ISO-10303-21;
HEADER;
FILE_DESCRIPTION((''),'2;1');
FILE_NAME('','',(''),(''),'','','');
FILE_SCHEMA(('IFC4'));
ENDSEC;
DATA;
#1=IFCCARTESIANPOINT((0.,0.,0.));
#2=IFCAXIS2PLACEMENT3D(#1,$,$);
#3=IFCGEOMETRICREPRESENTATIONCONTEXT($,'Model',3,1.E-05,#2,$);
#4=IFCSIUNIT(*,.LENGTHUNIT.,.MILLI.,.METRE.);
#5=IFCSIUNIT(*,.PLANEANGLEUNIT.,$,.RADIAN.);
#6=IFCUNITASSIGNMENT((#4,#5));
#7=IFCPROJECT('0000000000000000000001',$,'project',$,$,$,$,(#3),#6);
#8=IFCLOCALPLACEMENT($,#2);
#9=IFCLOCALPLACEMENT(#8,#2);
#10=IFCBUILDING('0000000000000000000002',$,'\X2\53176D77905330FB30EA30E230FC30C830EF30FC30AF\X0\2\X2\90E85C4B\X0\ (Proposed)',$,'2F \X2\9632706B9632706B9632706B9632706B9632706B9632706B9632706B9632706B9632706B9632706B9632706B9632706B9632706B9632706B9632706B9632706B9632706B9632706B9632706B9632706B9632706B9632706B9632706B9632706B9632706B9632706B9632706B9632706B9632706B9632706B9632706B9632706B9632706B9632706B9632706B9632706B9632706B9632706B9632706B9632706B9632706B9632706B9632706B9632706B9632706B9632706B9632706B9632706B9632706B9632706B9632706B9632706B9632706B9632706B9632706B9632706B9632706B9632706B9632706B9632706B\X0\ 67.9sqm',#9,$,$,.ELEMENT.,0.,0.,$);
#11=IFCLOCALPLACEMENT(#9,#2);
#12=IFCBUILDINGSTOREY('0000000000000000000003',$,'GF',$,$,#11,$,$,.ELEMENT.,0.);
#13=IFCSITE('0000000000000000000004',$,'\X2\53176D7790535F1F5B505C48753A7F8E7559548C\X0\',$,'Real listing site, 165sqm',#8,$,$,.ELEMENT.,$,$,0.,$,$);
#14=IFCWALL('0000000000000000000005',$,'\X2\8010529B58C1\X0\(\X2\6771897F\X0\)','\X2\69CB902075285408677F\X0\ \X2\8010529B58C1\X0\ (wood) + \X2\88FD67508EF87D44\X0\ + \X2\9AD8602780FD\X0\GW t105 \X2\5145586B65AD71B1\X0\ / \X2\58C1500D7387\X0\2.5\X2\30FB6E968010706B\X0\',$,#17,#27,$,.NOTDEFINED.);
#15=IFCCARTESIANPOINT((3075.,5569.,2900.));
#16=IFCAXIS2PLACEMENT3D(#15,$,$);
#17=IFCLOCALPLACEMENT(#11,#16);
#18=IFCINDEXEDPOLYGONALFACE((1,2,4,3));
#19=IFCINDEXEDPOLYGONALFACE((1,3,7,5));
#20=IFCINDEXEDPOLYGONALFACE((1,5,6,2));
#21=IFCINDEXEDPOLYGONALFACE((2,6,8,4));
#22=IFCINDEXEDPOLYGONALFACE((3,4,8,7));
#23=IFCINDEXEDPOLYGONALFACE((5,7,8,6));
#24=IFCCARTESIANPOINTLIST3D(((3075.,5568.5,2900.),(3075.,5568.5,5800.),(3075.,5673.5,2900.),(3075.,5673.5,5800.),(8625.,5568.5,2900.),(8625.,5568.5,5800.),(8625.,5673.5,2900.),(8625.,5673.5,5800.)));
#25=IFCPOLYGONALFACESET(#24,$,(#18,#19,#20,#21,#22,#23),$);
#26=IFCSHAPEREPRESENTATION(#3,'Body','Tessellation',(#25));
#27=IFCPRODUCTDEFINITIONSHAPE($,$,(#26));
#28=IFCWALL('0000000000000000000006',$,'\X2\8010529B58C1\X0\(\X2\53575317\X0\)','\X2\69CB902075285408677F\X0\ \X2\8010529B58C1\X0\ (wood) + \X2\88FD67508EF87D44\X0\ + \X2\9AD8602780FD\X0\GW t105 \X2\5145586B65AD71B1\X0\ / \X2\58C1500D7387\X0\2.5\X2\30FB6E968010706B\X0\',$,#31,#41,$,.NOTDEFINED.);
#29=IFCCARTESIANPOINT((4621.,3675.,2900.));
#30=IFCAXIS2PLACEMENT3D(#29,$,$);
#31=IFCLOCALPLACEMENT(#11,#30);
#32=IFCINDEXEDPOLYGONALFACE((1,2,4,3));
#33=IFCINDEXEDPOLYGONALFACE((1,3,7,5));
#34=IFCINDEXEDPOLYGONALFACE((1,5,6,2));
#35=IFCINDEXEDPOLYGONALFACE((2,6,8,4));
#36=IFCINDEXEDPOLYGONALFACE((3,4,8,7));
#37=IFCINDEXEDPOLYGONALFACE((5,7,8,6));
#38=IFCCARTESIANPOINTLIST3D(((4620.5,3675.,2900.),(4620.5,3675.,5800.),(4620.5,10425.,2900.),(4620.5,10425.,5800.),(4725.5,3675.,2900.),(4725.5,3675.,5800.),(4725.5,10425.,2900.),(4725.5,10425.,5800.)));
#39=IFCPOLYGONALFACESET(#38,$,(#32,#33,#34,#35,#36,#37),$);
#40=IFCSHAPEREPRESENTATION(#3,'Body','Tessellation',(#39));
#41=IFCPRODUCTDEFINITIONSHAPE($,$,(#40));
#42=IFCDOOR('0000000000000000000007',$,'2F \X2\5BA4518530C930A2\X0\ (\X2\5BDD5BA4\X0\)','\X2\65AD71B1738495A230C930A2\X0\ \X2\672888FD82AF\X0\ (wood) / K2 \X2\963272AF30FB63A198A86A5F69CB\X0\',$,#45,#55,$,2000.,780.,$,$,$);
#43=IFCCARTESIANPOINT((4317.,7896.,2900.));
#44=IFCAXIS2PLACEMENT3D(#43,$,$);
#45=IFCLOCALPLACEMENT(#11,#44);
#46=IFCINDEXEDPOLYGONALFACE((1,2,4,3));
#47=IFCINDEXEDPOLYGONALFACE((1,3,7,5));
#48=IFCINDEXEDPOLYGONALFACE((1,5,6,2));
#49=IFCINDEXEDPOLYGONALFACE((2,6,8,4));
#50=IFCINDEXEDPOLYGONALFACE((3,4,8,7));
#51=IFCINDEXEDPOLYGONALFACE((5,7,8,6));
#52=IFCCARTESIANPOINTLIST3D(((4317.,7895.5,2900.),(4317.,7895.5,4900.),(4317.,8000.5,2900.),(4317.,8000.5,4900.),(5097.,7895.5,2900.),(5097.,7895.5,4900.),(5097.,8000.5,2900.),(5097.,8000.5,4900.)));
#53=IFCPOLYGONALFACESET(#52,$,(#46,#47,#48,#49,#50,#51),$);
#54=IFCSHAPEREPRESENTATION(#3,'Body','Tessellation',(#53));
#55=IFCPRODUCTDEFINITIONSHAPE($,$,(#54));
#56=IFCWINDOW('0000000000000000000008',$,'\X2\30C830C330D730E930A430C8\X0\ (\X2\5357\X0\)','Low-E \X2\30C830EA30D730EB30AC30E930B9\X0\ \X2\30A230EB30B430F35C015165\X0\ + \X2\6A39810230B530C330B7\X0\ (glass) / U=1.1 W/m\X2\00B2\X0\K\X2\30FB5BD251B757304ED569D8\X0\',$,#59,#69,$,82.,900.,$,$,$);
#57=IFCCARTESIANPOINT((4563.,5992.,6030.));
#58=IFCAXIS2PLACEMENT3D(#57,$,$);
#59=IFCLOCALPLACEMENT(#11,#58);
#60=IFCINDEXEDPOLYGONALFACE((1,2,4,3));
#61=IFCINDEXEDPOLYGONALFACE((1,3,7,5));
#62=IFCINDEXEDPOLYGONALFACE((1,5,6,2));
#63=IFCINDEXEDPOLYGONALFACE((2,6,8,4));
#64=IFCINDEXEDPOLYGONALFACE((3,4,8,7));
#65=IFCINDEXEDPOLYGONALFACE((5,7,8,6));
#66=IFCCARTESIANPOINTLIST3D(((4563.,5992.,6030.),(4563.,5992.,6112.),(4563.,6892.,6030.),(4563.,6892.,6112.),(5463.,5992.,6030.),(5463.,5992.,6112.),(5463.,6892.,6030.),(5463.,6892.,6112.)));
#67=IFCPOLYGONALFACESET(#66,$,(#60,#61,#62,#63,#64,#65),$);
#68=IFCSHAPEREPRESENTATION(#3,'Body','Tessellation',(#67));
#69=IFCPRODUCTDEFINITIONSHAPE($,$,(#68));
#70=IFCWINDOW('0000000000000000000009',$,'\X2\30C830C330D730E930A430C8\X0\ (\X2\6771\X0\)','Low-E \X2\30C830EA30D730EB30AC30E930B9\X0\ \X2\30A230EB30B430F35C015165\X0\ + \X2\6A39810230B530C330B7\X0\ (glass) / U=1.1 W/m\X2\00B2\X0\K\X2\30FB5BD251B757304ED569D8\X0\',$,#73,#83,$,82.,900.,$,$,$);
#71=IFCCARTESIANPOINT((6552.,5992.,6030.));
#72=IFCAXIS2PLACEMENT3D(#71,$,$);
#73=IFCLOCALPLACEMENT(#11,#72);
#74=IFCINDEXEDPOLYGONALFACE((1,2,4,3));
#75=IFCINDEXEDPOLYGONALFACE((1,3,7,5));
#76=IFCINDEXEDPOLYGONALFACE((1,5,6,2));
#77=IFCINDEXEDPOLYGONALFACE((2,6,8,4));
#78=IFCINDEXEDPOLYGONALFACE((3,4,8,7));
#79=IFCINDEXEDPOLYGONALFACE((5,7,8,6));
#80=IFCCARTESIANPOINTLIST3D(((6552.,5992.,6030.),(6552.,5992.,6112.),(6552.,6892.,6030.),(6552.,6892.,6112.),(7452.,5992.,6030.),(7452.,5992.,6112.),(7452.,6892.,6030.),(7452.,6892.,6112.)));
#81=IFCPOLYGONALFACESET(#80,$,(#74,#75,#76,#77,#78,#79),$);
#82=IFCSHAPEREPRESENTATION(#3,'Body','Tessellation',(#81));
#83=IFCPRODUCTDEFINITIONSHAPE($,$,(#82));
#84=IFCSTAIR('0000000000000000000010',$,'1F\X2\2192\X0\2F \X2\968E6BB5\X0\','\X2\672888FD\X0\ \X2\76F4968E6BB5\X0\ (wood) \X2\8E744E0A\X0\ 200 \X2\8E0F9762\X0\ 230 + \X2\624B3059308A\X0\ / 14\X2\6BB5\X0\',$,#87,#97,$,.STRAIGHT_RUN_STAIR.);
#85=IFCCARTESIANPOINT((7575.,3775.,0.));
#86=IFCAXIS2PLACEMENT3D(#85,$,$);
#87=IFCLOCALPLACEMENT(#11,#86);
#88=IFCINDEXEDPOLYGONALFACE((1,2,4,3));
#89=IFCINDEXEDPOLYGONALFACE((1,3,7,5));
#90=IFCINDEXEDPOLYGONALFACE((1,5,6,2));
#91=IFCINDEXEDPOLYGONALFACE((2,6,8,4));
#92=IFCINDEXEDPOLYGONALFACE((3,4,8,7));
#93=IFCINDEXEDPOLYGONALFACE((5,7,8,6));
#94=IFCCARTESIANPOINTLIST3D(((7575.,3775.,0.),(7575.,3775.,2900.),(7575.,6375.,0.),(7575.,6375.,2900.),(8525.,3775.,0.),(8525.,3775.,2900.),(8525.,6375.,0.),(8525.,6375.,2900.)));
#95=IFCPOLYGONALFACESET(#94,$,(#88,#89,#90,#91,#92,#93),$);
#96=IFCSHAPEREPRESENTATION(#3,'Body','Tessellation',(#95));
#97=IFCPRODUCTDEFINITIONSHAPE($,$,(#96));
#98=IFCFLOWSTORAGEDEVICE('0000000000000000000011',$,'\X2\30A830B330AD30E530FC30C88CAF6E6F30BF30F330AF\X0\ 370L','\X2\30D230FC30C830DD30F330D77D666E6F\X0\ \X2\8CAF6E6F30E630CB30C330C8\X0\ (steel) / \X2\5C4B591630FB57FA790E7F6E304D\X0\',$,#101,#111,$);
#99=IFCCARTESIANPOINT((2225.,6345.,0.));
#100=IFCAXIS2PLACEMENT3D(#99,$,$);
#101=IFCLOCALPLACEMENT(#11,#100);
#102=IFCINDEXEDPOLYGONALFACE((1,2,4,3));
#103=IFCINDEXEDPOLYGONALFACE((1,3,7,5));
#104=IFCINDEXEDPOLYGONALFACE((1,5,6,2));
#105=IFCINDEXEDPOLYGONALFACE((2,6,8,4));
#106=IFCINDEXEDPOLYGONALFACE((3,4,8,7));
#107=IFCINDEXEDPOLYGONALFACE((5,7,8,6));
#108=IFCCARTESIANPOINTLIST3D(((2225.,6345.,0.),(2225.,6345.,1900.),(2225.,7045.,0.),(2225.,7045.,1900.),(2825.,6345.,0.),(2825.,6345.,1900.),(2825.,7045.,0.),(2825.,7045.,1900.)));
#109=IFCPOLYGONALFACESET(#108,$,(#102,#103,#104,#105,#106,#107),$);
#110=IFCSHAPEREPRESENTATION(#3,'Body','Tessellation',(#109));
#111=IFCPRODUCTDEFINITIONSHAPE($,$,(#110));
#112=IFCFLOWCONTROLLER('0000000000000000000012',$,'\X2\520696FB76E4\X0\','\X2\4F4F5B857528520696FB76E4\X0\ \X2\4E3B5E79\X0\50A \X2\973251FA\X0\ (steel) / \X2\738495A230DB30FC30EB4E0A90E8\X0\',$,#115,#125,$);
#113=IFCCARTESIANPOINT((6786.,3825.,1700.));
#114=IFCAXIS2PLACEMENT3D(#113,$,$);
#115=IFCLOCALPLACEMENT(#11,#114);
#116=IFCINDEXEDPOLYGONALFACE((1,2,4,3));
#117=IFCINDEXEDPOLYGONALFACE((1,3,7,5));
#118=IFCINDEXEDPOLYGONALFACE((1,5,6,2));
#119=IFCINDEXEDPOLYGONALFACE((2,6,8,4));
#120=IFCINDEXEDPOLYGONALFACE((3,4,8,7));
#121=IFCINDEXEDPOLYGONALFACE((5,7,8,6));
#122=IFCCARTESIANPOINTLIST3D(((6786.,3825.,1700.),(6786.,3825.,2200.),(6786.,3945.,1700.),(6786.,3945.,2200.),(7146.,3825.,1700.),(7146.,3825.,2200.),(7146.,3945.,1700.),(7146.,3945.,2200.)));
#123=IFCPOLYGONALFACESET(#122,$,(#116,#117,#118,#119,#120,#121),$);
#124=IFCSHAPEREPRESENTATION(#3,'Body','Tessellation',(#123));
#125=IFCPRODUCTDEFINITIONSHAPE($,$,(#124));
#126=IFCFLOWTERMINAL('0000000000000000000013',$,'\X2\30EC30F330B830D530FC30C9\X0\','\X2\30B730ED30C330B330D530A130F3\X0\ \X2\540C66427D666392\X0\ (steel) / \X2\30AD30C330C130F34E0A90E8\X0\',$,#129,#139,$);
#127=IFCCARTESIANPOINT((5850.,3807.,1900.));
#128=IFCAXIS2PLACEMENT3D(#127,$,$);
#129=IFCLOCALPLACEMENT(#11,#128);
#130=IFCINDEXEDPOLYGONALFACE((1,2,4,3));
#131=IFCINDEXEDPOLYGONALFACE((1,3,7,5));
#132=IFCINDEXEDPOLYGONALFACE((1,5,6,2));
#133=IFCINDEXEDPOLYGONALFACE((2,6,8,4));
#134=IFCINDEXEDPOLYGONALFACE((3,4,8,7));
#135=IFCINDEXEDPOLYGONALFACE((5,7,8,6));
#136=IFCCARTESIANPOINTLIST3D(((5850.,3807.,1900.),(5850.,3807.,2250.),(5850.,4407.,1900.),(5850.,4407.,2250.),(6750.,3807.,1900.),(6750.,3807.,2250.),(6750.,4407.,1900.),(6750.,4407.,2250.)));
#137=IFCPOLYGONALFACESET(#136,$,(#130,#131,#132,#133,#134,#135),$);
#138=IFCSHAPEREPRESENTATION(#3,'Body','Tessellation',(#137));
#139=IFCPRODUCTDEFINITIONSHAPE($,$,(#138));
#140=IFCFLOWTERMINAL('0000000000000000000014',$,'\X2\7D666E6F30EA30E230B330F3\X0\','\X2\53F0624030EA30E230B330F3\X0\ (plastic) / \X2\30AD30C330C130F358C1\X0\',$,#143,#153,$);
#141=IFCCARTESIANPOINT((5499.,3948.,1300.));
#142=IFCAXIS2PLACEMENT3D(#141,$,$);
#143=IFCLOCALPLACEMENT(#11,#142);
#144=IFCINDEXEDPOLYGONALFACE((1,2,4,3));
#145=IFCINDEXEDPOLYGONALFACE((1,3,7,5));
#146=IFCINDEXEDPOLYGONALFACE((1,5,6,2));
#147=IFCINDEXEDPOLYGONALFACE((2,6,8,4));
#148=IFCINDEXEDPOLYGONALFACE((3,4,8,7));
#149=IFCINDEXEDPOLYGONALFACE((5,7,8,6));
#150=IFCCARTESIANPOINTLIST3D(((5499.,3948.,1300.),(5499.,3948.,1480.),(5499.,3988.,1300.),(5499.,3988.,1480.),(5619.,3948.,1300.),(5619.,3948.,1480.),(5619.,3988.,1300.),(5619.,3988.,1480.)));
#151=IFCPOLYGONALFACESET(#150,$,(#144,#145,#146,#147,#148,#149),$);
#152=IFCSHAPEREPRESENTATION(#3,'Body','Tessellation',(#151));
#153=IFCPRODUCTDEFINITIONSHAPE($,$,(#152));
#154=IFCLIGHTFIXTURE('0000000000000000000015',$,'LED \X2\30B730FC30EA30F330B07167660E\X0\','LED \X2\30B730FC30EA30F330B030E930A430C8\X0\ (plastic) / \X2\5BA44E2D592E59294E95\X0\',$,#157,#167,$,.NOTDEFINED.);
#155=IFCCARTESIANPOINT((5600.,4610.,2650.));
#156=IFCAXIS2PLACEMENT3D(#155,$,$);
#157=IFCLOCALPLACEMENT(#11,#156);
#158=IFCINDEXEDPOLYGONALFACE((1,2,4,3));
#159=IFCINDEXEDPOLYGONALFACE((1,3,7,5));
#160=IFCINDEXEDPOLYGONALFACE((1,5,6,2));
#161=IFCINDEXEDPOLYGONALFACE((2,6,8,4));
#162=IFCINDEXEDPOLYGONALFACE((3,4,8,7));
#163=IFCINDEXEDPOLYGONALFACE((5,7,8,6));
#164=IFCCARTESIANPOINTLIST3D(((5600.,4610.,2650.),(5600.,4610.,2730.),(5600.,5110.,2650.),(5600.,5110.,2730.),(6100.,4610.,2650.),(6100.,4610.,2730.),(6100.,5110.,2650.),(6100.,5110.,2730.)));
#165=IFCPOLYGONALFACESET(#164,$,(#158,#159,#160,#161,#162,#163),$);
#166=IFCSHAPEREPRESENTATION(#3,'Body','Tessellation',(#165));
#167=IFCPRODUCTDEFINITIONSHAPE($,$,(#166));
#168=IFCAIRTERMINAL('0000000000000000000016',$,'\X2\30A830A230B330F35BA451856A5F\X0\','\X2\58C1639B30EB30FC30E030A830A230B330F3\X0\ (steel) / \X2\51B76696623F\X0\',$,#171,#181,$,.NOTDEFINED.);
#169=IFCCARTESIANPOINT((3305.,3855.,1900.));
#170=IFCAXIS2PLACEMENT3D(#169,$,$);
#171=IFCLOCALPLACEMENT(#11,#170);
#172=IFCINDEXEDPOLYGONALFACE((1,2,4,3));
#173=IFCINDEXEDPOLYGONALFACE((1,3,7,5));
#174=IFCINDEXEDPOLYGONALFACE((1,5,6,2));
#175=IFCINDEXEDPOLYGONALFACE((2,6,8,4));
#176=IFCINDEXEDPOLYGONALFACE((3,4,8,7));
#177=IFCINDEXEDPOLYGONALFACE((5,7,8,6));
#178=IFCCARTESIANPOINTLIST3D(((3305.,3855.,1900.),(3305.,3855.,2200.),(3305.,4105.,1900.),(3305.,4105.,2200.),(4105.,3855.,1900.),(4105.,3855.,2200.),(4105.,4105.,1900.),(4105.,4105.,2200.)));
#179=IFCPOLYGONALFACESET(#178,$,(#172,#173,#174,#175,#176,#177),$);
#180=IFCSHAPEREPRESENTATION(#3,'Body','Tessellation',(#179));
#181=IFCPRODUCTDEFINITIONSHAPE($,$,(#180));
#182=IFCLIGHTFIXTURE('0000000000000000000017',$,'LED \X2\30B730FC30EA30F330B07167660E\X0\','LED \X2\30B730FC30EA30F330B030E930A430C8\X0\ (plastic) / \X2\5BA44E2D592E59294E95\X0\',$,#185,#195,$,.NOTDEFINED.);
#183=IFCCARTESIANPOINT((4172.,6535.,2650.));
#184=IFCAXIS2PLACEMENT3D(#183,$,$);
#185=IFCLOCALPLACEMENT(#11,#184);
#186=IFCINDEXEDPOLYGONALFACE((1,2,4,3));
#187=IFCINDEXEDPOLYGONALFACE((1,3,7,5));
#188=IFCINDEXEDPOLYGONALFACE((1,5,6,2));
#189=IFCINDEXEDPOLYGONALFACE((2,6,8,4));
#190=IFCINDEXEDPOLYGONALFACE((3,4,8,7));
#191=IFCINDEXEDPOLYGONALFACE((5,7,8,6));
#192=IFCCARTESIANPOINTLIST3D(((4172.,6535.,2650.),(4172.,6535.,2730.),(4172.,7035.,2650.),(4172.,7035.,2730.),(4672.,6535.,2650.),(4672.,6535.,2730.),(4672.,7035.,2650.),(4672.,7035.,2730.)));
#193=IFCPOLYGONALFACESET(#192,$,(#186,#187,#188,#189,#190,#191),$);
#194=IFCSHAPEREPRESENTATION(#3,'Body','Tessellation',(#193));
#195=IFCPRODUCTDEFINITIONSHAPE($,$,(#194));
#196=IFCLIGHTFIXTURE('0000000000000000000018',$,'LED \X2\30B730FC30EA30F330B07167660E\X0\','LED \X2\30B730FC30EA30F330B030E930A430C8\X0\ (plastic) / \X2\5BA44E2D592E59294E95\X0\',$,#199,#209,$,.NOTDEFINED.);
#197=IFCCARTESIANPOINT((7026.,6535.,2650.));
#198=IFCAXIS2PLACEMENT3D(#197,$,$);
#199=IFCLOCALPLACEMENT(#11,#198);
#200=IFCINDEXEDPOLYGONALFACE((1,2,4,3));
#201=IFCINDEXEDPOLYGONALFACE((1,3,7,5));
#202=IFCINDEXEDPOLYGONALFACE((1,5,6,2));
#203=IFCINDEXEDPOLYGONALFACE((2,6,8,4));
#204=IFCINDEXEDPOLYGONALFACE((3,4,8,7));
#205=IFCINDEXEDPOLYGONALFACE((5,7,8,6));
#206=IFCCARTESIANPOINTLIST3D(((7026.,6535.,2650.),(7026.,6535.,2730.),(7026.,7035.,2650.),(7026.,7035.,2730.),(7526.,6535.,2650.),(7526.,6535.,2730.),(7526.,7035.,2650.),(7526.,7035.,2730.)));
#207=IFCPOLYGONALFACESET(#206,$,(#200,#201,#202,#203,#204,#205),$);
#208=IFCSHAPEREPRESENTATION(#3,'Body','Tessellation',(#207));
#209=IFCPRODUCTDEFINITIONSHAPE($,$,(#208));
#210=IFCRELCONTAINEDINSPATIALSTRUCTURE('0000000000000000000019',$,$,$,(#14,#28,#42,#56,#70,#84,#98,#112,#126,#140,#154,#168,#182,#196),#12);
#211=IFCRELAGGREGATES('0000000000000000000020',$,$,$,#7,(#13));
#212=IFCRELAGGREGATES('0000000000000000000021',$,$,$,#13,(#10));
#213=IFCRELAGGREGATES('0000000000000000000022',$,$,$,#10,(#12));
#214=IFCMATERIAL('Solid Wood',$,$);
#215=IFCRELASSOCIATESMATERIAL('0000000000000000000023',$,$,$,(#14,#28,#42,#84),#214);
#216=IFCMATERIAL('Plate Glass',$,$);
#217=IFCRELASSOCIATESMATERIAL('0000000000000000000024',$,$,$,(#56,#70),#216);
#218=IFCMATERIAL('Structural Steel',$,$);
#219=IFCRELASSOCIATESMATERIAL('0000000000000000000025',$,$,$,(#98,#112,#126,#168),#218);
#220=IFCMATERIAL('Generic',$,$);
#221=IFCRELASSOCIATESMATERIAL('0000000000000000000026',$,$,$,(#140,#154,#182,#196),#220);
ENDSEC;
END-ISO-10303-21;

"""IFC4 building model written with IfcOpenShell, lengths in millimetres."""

from ifc_helpers import new_model, si_unit, frame, frame_2d, origin, place, context, project, spatial, rectangle, extrude, material, element, fill, save


model = new_model("IFC4")

# Units and contexts
model_context = context("Model", 3, precision=1e-05, world=origin())
ifc_project = project(units=[si_unit("LENGTHUNIT", "METRE", prefix="MILLI"), si_unit("PLANEANGLEUNIT", "RADIAN")], contexts=[model_context])

# Site, building, storey
site_placement = place(None, origin())
site = spatial("IfcSite", under=ifc_project, at=site_placement, Name="北海道弟子屈町美留和", ObjectType="Real listing site, 165sqm", CompositionType="ELEMENT", RefElevation=0.0)
building_placement = place(site_placement, origin())
building = spatial("IfcBuilding", under=site, at=building_placement, Name="北海道・リモートワーク2部屋 (Proposed)", ObjectType="2F 防火防火防火防火防火防火防火防火防火防火防火防火防火防火防火防火防火防火防火防火防火防火防火防火防火防火防火防火防火防火防火防火防火防火防火防火防火防火防火防火防火防火防火防火防火防火防火防火防火防火防火防火防火防火防火防火防火防火防火防火 67.9sqm", CompositionType="ELEMENT", ElevationOfRefHeight=0.0, ElevationOfTerrain=0.0)
storey_placement = place(building_placement, origin())
storey = spatial("IfcBuildingStorey", under=building, at=storey_placement, Name="GF", CompositionType="ELEMENT", Elevation=0.0)

# Shared definitions
ifc_material_1 = material(Name="Solid Wood")

# Wall
wall_1_placement = place(storey_placement, frame((3075.0, 5569.0, 2900.0)))
element("IfcWall", 1, at=wall_1_placement, inside=storey, material=ifc_material_1, Name="耐力壁(東西)", Description="構造用合板 耐力壁 (wood) + 製材軸組 + 高性能GW t105 充填断熱 / 壁倍率2.5・準耐火", PredefinedType="NOTDEFINED", context=model_context, shape_type="SweptSolid", body=[
    extrude(rectangle(XDim=5550.0, YDim=105.0, at=frame_2d((2775.0, 52.0))), frame((3075.0, 5569.0, 2900.0)), (0.0, 0.0, 1.0), 2900.0),
])

# Wall, opening, door
wall_2_placement = place(storey_placement, frame((4621.0, 3675.0, 2900.0)))
wall_2 = element("IfcWall", 2, at=wall_2_placement, inside=storey, material=ifc_material_1, Name="耐力壁(南北)", Description="構造用合板 耐力壁 (wood) + 製材軸組 + 高性能GW t105 充填断熱 / 壁倍率2.5・準耐火", PredefinedType="NOTDEFINED", context=model_context, shape_type="SweptSolid", body=[
    extrude(rectangle(XDim=105.0, YDim=6750.0, at=frame_2d((52.0, 3375.0))), frame((4621.0, 3675.0, 2900.0)), (0.0, 0.0, 1.0), 2900.0),
])
opening_placement = place(storey_placement, frame((4317.0, 7896.0, 2900.0)))
opening = element("IfcOpeningElement", 3, at=opening_placement, cuts=wall_2, PredefinedType="NOTDEFINED", context=model_context, shape_type="SweptSolid", body=[
    extrude(rectangle(XDim=780.0, YDim=105.0, at=frame_2d((390.0, 52.0))), frame((4317.0, 7896.0, 2900.0)), (0.0, 0.0, 1.0), 2000.0),
])
door_placement = place(storey_placement, frame((4317.0, 7896.0, 2900.0)))
door = element("IfcDoor", 4, at=door_placement, inside=storey, material=ifc_material_1, Name="2F 室内ドア (寝室)", Description="断熱玄関ドア 木製芯 (wood) / K2 防犯・採風機構", OverallHeight=2000.0, OverallWidth=780.0, context=model_context, shape_type="SweptSolid", body=[
    extrude(rectangle(XDim=780.0, YDim=105.0, at=frame_2d((390.0, 52.0))), frame((4317.0, 7896.0, 2900.0)), (0.0, 0.0, 1.0), 2000.0),
])
fill(opening, door)

# Windows
ifc_material_2 = material(Name="Plate Glass")
window_1_placement = place(storey_placement, frame((4563.0, 5992.0, 6030.0)))
element("IfcWindow", 5, at=window_1_placement, inside=storey, material=ifc_material_2, Name="トップライト (南)", Description="Low-E トリプルガラス アルゴン封入 + 樹脂サッシ (glass) / U=1.1 W/m²K・寒冷地仕様", OverallHeight=82.0, OverallWidth=900.0, context=model_context, shape_type="SweptSolid", body=[
    extrude(rectangle(XDim=900.0, YDim=900.0, at=frame_2d((450.0, 450.0))), frame((4563.0, 5992.0, 6030.0)), (0.0, 0.0, 1.0), 82.0),
])
window_2_placement = place(storey_placement, frame((6552.0, 5992.0, 6030.0)))
element("IfcWindow", 6, at=window_2_placement, inside=storey, material=ifc_material_2, Name="トップライト (東)", Description="Low-E トリプルガラス アルゴン封入 + 樹脂サッシ (glass) / U=1.1 W/m²K・寒冷地仕様", OverallHeight=82.0, OverallWidth=900.0, context=model_context, shape_type="SweptSolid", body=[
    extrude(rectangle(XDim=900.0, YDim=900.0, at=frame_2d((450.0, 450.0))), frame((6552.0, 5992.0, 6030.0)), (0.0, 0.0, 1.0), 82.0),
])

# Stair
stair_placement = place(storey_placement, frame((7575.0, 3775.0, 0.0)))
element("IfcStair", 7, at=stair_placement, inside=storey, material=ifc_material_1, Name="1F→2F 階段", Description="木製 直階段 (wood) 蹴上 200 踏面 230 + 手すり / 14段", PredefinedType="STRAIGHT_RUN_STAIR", context=model_context, shape_type="SweptSolid", body=[
    extrude(rectangle(XDim=950.0, YDim=2600.0, at=frame_2d((475.0, 1300.0))), frame((7575.0, 3775.0, 0.0)), (0.0, 0.0, 1.0), 2900.0),
])

# Flow storage device
ifc_material_3 = material(Name="Structural Steel")
flow_storage_device_placement = place(storey_placement, frame((2225.0, 6345.0, 0.0)))
element("IfcFlowStorageDevice", 8, at=flow_storage_device_placement, inside=storey, material=ifc_material_3, Name="エコキュート貯湯タンク 370L", Description="ヒートポンプ給湯 貯湯ユニット (steel) / 屋外・基礎置き", context=model_context, shape_type="SweptSolid", body=[
    extrude(rectangle(XDim=600.0, YDim=700.0, at=frame_2d((300.0, 350.0))), frame((2225.0, 6345.0, 0.0)), (0.0, 0.0, 1.0), 1900.0),
])

# Flow controller
flow_controller_placement = place(storey_placement, frame((6786.0, 3825.0, 1700.0)))
element("IfcFlowController", 9, at=flow_controller_placement, inside=storey, material=ifc_material_3, Name="分電盤", Description="住宅用分電盤 主幹50A 露出 (steel) / 玄関ホール上部", context=model_context, shape_type="SweptSolid", body=[
    extrude(rectangle(XDim=360.0, YDim=120.0, at=frame_2d((180.0, 60.0))), frame((6786.0, 3825.0, 1700.0)), (0.0, 0.0, 1.0), 500.0),
])

# Flow terminals
flow_terminal_1_placement = place(storey_placement, frame((5850.0, 3807.0, 1900.0)))
element("IfcFlowTerminal", 10, at=flow_terminal_1_placement, inside=storey, material=ifc_material_3, Name="レンジフード", Description="シロッコファン 同時給排 (steel) / キッチン上部", context=model_context, shape_type="SweptSolid", body=[
    extrude(rectangle(XDim=900.0, YDim=600.0, at=frame_2d((450.0, 300.0))), frame((5850.0, 3807.0, 1900.0)), (0.0, 0.0, 1.0), 350.0),
])
ifc_material_4 = material(Name="Generic")
flow_terminal_2_placement = place(storey_placement, frame((5499.0, 3948.0, 1300.0)))
element("IfcFlowTerminal", 11, at=flow_terminal_2_placement, inside=storey, material=ifc_material_4, Name="給湯リモコン", Description="台所リモコン (plastic) / キッチン壁", context=model_context, shape_type="SweptSolid", body=[
    extrude(rectangle(XDim=120.0, YDim=40.0, at=frame_2d((60.0, 20.0))), frame((5499.0, 3948.0, 1300.0)), (0.0, 0.0, 1.0), 180.0),
])

# Light fixture
light_fixture_1_placement = place(storey_placement, frame((5600.0, 4610.0, 2650.0)))
element("IfcLightFixture", 12, at=light_fixture_1_placement, inside=storey, material=ifc_material_4, Name="LED シーリング照明", Description="LED シーリングライト (plastic) / 室中央天井", PredefinedType="NOTDEFINED", context=model_context, shape_type="SweptSolid", body=[
    extrude(rectangle(XDim=500.0, YDim=500.0, at=frame_2d((250.0, 250.0))), frame((5600.0, 4610.0, 2650.0)), (0.0, 0.0, 1.0), 80.0),
])

# Air terminal
air_terminal_1_placement = place(storey_placement, frame((3305.0, 3855.0, 1900.0)))
element("IfcAirTerminal", 13, at=air_terminal_1_placement, inside=storey, material=ifc_material_3, Name="エアコン室内機", Description="壁掛ルームエアコン (steel) / 冷暖房", PredefinedType="NOTDEFINED", context=model_context, shape_type="SweptSolid", body=[
    extrude(rectangle(XDim=800.0, YDim=250.0, at=frame_2d((400.0, 125.0))), frame((3305.0, 3855.0, 1900.0)), (0.0, 0.0, 1.0), 300.0),
])

# Light fixtures
light_fixture_2_placement = place(storey_placement, frame((4172.0, 6535.0, 2650.0)))
element("IfcLightFixture", 14, at=light_fixture_2_placement, inside=storey, material=ifc_material_4, Name="LED シーリング照明", Description="LED シーリングライト (plastic) / 室中央天井", PredefinedType="NOTDEFINED", context=model_context, shape_type="SweptSolid", body=[
    extrude(rectangle(XDim=500.0, YDim=500.0, at=frame_2d((250.0, 250.0))), frame((4172.0, 6535.0, 2650.0)), (0.0, 0.0, 1.0), 80.0),
])
light_fixture_3_placement = place(storey_placement, frame((7026.0, 6535.0, 2650.0)))
element("IfcLightFixture", 15, at=light_fixture_3_placement, inside=storey, material=ifc_material_4, Name="LED シーリング照明", Description="LED シーリングライト (plastic) / 室中央天井", PredefinedType="NOTDEFINED", context=model_context, shape_type="SweptSolid", body=[
    extrude(rectangle(XDim=500.0, YDim=500.0, at=frame_2d((250.0, 250.0))), frame((7026.0, 6535.0, 2650.0)), (0.0, 0.0, 1.0), 80.0),
])

save(model, "model.ifc")
